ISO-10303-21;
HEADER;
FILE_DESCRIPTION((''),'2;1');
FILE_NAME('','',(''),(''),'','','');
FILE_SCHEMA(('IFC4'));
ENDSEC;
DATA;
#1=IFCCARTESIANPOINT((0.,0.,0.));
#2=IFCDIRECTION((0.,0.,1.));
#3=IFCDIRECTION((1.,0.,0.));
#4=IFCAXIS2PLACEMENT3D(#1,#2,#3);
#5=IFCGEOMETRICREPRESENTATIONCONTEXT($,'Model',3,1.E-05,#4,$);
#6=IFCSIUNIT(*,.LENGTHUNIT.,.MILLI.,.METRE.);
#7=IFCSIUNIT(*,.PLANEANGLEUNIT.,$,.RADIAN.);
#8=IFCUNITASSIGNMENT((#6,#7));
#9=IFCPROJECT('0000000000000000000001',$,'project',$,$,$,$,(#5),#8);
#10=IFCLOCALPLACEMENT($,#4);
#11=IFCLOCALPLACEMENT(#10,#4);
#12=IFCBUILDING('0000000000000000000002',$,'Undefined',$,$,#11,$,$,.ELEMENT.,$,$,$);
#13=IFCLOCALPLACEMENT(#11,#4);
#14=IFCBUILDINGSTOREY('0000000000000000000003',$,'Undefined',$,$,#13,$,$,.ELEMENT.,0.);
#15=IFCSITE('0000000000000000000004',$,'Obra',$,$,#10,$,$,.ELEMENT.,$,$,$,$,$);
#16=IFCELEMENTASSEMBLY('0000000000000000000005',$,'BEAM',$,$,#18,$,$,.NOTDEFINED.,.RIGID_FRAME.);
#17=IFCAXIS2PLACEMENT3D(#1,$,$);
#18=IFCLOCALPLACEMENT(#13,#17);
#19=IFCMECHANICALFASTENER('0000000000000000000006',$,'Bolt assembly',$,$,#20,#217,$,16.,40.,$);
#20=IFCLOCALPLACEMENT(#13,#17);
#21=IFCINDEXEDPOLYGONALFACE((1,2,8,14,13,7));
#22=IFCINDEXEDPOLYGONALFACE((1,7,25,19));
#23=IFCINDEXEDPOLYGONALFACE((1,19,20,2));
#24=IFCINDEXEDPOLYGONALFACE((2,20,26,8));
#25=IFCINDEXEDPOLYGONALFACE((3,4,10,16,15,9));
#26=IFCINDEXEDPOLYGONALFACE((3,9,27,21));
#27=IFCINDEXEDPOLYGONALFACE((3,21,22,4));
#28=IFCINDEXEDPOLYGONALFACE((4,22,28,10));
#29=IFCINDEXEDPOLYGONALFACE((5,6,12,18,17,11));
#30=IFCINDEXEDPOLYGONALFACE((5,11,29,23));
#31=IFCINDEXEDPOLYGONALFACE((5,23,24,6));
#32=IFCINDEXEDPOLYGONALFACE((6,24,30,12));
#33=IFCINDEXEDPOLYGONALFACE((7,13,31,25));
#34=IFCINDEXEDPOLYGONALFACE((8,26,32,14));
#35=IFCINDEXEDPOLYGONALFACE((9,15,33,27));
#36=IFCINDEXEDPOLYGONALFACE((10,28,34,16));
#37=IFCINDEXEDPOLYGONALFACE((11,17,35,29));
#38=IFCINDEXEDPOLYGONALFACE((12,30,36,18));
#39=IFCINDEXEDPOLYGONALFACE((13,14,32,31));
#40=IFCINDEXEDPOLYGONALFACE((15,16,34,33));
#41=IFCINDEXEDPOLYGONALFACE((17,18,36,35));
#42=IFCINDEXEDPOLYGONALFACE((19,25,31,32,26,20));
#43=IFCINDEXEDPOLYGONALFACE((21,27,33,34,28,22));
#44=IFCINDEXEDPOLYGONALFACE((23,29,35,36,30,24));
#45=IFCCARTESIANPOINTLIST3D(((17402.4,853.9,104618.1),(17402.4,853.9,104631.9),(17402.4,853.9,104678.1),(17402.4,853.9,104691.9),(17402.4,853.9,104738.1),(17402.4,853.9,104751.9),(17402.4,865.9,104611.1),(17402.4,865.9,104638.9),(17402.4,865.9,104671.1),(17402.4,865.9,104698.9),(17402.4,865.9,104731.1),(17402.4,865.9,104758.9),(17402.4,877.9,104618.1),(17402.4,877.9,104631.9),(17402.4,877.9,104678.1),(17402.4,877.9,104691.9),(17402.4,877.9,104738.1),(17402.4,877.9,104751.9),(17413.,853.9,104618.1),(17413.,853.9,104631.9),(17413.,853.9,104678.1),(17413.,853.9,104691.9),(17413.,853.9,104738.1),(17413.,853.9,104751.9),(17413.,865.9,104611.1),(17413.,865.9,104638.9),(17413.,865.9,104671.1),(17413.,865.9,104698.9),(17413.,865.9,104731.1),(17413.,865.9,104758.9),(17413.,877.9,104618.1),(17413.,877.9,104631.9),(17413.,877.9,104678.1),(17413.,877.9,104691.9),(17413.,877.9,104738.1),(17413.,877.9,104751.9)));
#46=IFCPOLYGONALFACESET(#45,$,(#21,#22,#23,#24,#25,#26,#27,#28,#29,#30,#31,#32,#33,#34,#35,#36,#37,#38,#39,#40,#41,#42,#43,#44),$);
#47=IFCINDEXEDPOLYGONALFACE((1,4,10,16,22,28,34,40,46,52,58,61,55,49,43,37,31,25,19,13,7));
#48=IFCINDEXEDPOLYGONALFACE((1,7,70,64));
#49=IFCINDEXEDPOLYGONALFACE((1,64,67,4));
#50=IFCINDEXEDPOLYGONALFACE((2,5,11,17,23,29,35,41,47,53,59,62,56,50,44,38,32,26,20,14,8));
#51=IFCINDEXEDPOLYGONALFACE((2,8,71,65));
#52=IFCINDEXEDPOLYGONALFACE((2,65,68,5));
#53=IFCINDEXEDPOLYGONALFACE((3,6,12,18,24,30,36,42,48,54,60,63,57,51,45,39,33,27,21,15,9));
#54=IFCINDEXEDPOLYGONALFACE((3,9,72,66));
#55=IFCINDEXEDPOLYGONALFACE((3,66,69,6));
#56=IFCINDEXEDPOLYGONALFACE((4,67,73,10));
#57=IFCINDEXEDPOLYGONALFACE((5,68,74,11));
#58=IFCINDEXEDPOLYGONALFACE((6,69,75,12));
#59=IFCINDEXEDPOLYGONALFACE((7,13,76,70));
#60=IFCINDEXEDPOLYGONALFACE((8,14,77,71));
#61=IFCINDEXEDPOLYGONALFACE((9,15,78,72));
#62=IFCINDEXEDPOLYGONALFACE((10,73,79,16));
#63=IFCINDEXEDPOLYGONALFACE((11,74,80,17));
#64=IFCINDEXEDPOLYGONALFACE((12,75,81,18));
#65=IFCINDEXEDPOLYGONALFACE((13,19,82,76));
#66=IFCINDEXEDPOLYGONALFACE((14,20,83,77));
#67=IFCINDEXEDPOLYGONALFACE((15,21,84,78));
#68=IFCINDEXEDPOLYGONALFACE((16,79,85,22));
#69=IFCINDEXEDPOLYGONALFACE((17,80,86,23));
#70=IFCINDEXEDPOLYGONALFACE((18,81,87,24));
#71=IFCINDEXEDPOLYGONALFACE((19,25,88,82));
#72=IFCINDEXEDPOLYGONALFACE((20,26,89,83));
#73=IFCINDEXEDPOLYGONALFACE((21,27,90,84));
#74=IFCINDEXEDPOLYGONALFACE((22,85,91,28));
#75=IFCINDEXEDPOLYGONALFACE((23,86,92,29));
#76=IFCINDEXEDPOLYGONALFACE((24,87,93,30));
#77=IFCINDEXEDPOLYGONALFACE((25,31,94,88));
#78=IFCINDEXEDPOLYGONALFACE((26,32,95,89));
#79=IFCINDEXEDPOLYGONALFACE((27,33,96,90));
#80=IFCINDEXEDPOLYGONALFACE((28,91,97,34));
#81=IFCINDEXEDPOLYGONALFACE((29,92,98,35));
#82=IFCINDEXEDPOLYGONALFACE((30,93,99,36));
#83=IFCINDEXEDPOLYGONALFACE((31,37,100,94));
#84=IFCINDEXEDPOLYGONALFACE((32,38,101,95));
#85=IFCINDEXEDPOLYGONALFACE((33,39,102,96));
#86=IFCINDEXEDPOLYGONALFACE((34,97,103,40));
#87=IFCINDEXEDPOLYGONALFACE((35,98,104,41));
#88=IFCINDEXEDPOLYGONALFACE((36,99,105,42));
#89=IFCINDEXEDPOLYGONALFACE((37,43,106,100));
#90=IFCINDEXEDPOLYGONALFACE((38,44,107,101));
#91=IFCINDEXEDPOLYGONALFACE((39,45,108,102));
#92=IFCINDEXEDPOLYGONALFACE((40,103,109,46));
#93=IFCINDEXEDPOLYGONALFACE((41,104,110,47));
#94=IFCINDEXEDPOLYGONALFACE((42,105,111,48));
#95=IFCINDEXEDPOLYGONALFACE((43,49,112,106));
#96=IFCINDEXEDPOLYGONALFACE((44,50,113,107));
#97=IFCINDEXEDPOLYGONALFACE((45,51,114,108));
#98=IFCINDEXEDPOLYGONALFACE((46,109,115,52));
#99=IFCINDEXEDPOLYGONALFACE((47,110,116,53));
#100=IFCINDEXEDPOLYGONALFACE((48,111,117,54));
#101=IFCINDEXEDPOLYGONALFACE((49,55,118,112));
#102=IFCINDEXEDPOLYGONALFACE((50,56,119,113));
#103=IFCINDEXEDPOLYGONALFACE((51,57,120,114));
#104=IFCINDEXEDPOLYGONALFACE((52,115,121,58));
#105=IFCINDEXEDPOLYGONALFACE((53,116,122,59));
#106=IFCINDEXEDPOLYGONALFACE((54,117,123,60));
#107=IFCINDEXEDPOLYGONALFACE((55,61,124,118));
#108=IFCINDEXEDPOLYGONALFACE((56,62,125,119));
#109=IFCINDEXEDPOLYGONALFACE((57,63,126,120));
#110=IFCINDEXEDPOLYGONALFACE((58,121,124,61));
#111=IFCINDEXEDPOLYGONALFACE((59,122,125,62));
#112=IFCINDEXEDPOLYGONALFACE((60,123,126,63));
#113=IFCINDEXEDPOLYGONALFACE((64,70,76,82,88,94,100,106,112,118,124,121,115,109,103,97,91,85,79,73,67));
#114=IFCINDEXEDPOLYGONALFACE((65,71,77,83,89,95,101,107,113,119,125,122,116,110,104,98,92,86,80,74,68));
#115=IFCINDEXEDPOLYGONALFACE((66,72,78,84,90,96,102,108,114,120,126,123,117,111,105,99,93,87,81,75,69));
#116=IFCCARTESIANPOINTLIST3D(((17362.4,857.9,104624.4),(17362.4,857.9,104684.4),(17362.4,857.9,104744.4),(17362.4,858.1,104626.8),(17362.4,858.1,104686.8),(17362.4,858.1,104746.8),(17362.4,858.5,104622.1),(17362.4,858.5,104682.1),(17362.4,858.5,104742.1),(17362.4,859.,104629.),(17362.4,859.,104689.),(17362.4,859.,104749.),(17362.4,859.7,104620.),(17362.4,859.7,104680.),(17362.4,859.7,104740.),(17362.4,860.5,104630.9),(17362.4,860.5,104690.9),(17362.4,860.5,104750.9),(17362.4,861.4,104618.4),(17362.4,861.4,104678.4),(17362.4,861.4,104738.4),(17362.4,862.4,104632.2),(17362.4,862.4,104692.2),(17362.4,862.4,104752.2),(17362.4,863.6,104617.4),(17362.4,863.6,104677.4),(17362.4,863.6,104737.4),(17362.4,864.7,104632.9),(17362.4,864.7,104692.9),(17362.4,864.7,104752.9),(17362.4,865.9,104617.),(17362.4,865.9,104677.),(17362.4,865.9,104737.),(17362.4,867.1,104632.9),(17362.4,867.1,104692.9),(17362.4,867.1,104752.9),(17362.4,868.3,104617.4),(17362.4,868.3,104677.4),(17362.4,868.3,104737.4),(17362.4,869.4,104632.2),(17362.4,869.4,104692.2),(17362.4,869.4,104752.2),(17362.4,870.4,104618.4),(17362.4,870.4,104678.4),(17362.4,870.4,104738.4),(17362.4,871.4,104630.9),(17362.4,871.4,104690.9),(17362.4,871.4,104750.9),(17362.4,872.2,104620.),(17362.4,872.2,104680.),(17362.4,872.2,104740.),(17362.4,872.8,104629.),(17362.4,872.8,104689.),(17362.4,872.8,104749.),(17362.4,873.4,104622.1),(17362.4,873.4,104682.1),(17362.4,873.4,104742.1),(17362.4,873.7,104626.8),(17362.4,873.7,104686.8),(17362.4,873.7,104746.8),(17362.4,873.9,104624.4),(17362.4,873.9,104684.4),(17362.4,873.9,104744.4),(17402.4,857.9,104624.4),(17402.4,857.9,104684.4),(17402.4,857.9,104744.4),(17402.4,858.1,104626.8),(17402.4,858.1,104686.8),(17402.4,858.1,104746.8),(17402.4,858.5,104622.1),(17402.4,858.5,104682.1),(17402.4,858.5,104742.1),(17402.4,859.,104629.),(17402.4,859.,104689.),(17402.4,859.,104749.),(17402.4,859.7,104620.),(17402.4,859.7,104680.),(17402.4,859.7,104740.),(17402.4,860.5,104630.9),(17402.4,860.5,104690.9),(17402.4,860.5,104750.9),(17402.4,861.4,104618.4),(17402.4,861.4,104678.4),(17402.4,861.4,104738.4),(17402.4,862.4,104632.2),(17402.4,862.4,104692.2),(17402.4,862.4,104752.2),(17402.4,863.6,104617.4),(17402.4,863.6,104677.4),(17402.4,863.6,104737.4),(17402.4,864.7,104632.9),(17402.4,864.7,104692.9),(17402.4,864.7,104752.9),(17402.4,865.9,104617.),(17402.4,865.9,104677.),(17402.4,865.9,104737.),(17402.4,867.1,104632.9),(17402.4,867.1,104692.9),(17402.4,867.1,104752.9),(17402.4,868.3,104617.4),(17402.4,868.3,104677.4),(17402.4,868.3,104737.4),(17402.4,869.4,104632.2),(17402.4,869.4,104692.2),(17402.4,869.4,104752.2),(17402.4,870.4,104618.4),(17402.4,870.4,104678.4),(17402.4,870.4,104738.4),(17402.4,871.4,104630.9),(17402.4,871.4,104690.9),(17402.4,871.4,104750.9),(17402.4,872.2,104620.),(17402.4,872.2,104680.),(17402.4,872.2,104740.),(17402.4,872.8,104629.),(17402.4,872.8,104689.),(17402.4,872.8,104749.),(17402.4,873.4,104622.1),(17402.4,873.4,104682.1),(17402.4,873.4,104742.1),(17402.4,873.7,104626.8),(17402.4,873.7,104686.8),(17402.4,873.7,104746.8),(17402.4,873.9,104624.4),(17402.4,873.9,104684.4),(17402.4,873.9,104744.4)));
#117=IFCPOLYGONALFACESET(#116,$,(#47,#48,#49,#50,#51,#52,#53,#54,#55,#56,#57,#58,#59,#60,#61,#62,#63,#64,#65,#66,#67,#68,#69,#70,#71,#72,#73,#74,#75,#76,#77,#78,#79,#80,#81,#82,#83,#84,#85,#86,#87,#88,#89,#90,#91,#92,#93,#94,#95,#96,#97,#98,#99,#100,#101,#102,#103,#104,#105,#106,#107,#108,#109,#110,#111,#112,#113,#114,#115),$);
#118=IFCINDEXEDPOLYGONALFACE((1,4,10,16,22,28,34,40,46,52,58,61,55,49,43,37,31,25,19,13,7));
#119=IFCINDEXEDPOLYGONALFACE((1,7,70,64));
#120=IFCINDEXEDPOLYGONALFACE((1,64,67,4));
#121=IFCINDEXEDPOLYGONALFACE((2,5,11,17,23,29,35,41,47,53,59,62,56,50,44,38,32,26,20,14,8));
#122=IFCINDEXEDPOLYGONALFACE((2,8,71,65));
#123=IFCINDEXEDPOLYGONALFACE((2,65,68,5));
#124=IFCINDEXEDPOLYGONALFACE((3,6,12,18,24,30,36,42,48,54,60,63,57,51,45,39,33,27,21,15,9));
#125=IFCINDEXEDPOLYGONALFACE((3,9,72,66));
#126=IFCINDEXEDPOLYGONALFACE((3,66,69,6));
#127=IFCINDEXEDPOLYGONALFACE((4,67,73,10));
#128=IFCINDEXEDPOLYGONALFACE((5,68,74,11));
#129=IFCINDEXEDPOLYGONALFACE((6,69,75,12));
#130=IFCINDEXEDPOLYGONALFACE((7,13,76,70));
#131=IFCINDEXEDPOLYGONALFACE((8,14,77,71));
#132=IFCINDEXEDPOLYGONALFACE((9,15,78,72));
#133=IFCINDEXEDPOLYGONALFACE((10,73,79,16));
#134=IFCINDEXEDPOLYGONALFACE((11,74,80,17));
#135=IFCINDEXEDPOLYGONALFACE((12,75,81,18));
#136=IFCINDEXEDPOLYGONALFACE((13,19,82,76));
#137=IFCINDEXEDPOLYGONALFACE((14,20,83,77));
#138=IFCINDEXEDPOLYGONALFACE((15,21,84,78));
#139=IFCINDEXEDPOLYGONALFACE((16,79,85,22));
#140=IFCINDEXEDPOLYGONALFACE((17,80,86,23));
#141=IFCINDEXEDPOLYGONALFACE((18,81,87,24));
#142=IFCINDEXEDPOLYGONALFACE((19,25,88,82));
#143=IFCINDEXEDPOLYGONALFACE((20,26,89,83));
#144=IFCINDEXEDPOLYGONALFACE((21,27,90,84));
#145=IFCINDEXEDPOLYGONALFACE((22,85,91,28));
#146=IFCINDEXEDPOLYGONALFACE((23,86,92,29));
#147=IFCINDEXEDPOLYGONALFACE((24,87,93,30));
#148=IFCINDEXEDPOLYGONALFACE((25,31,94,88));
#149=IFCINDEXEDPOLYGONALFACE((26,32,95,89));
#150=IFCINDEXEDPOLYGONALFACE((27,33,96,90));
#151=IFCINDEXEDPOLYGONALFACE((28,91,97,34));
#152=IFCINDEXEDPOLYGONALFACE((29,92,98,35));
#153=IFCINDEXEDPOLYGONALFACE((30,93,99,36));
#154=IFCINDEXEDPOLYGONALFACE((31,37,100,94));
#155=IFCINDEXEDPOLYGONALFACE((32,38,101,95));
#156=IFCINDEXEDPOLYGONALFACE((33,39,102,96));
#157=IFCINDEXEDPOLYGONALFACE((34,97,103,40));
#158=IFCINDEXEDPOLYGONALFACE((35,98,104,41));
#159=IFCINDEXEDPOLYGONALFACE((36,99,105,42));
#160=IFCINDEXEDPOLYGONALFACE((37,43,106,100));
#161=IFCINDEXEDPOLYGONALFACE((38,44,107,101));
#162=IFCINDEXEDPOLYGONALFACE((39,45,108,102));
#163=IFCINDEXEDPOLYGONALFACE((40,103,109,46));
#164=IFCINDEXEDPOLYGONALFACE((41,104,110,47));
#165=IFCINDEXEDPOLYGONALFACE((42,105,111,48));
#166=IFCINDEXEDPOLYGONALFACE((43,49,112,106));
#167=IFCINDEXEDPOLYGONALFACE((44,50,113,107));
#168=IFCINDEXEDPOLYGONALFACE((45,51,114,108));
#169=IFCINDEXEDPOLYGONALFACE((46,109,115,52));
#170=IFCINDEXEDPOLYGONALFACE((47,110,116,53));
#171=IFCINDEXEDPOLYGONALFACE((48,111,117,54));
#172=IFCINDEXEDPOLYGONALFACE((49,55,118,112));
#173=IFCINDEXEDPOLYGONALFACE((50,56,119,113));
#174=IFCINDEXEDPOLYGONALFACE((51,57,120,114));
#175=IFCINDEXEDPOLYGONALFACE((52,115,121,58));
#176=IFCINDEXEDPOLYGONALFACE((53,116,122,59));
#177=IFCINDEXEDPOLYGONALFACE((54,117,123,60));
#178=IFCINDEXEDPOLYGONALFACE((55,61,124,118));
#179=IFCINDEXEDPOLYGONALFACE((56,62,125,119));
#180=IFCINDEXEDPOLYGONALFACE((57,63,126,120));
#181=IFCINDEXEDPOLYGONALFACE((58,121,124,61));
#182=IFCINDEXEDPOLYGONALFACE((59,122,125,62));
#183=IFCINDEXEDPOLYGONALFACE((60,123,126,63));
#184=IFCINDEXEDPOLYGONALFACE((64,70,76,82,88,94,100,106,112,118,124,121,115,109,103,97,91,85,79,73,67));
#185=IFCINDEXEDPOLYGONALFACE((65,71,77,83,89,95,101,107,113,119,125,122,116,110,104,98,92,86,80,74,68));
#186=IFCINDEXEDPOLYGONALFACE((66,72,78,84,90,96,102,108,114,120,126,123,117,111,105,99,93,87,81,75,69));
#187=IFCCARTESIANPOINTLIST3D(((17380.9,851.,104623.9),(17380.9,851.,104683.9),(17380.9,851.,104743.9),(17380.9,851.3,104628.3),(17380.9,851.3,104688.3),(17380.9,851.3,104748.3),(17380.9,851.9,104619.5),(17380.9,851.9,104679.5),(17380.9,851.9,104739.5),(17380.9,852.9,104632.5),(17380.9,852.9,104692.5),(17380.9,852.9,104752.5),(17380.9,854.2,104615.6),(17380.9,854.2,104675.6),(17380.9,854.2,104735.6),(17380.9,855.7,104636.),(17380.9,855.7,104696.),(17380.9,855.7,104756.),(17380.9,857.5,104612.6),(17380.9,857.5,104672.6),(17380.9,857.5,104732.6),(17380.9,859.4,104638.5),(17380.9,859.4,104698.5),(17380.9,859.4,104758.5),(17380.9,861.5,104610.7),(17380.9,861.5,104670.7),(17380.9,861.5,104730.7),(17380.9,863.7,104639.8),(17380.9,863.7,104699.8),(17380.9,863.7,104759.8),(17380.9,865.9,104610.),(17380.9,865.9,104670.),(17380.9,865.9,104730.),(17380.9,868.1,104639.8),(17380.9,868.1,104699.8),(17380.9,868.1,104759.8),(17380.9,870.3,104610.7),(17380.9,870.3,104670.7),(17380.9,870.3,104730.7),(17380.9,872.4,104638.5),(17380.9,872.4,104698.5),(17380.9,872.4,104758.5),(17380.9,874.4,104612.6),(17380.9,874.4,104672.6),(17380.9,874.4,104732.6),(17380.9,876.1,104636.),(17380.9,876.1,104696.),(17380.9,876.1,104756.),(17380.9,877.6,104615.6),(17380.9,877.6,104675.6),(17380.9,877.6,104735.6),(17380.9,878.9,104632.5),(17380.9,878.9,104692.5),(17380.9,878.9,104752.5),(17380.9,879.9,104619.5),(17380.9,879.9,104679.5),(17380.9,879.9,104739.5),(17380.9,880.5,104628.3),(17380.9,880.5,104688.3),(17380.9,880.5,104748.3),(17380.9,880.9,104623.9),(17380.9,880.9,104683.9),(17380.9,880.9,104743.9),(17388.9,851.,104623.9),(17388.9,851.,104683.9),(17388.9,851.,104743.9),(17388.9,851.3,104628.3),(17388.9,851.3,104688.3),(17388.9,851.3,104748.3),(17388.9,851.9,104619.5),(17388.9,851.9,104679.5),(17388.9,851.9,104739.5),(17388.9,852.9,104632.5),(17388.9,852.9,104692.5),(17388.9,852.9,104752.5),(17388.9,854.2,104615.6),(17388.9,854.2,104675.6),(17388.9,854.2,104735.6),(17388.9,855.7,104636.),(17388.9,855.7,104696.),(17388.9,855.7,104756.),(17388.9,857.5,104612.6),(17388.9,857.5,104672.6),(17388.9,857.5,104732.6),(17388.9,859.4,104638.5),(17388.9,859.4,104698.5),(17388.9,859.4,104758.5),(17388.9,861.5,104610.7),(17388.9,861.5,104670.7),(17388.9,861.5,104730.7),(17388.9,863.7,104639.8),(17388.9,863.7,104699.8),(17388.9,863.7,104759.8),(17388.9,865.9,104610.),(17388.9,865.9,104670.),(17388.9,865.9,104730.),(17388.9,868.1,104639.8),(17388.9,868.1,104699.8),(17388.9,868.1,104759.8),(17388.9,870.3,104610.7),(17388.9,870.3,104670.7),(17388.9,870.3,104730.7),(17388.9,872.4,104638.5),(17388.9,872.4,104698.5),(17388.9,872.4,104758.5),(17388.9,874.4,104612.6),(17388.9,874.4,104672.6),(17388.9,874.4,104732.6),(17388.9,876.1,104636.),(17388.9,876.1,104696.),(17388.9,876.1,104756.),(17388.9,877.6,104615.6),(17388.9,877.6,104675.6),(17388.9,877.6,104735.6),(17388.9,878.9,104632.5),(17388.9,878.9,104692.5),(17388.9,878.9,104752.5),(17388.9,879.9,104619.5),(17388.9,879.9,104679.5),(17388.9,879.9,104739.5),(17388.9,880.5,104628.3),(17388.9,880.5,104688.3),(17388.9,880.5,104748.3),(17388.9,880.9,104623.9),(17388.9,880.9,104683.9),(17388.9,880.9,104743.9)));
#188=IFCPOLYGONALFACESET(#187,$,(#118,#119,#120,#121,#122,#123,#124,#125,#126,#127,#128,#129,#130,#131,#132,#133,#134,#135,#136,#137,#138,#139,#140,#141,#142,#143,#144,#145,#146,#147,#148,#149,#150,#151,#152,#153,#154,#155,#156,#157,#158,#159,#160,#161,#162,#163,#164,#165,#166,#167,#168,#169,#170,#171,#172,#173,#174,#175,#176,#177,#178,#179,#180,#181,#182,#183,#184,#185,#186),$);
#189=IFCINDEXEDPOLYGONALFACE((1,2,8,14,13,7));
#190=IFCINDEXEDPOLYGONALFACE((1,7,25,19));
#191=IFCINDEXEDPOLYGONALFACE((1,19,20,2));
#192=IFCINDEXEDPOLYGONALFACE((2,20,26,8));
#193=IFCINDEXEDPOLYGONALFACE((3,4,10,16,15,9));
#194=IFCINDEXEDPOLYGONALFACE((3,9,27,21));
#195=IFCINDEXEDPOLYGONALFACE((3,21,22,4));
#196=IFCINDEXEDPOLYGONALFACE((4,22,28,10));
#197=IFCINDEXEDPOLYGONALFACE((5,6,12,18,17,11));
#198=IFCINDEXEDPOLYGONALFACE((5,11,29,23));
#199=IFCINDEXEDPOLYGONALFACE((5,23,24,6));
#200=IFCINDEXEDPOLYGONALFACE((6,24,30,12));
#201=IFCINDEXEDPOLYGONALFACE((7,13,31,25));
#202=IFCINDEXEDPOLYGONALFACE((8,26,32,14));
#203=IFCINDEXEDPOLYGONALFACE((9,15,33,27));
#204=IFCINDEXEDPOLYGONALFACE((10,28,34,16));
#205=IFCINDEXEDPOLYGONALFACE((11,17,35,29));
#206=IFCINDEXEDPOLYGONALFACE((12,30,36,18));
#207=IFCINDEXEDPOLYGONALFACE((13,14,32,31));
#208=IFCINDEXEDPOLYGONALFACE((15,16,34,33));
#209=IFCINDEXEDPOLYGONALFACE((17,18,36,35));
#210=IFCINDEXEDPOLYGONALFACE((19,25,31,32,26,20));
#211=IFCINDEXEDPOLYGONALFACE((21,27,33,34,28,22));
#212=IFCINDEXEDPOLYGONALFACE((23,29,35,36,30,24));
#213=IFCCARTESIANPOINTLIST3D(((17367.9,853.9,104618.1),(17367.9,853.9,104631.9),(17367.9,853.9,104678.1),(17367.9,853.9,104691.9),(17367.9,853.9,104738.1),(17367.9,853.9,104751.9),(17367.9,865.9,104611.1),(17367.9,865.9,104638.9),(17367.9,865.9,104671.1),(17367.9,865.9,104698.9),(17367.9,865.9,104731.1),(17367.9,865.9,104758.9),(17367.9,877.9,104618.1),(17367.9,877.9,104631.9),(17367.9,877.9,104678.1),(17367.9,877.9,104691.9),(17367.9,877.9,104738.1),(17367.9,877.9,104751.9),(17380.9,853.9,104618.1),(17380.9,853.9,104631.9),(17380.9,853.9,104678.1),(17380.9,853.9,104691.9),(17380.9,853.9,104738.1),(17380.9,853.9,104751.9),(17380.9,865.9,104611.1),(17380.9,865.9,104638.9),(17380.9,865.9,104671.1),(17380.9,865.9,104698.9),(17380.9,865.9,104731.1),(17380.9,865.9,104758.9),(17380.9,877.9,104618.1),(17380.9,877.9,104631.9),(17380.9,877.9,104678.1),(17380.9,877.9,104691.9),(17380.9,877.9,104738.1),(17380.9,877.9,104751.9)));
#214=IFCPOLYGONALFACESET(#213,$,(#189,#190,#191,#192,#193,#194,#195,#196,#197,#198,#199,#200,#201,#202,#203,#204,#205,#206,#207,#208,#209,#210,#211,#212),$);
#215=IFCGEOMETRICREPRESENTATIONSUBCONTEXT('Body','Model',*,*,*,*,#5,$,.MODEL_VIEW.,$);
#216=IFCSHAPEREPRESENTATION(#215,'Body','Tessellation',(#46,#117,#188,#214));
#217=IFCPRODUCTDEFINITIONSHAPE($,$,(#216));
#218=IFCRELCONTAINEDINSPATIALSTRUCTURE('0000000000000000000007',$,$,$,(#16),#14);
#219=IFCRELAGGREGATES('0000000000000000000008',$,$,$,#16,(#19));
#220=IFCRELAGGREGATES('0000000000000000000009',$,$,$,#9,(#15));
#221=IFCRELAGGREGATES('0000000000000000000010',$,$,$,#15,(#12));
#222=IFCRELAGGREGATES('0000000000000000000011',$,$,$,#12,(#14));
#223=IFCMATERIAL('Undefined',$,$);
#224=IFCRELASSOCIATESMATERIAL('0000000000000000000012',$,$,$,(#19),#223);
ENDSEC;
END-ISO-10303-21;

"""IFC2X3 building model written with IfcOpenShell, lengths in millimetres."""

from ifc_helpers import new_model, si_unit, frame, origin_with_axes, origin_2d_with_axis, place, context, subcontext, project, spatial, polyline, circle, outline, extrude, source, transform, mapped, material, element, aggregate, save


model = new_model("IFC2X3")

# Units and contexts
model_context = context("Model", 3, precision=1e-05, world=origin_with_axes())
body_context = subcontext(model_context, "Body", "Model", "MODEL_VIEW")
ifc_project = project(units=[si_unit("LENGTHUNIT", "METRE", prefix="MILLI"), si_unit("PLANEANGLEUNIT", "RADIAN")], contexts=[model_context])

# Site, building, storey
site_placement = place(None, origin_with_axes())
site = spatial("IfcSite", under=ifc_project, at=site_placement, Name="Obra", CompositionType="ELEMENT")
building_placement = place(site_placement, origin_with_axes())
building = spatial("IfcBuilding", under=site, at=building_placement, Name="Undefined", CompositionType="ELEMENT")
storey_placement = place(building_placement, origin_with_axes())
storey = spatial("IfcBuildingStorey", under=building, at=storey_placement, Name="Undefined", CompositionType="ELEMENT", Elevation=0.0)

# Shared definitions
ifc_material_1 = material(Name="Undefined")
shared_shape_1 = source(origin_with_axes(), body_context, "Body", "SweptSolid", [
    extrude(outline(polyline([(13.9, 0.0), (6.9, 12.0), (-6.9, 12.0), (-13.9, 0.0), (-6.9, -12.0), (6.9, -12.0), (13.9, 0.0)])), frame((0.0, -20.3, 0.0), z_axis=(0.0, 1.0, 0.0), x_axis=(1.0, 0.0, 0.0)), (0.0, 0.0, 1.0), 10.6),
    extrude(circle(Radius=8.0, at=origin_2d_with_axis()), frame((0.0, -9.8, 0.0), z_axis=(0.0, 1.0, 0.0), x_axis=(1.0, 0.0, 0.0)), (0.0, 0.0, 1.0), 40.0),
    extrude(circle(Radius=15.0, at=origin_2d_with_axis()), frame((0.0, 3.7, 0.0), z_axis=(0.0, 1.0, 0.0), x_axis=(1.0, 0.0, 0.0)), (0.0, 0.0, 1.0), 8.0),
    extrude(outline(polyline([(13.9, 0.0), (6.9, 12.0), (-6.9, 12.0), (-13.9, 0.0), (-6.9, -12.0), (6.9, -12.0), (13.9, 0.0)])), frame((0.0, 11.7, 0.0), z_axis=(0.0, 1.0, 0.0), x_axis=(1.0, 0.0, 0.0)), (0.0, 0.0, 1.0), 13.0),
])

# Element assembly, mechanical fastener
assembly_1_placement = place(storey_placement, origin_with_axes())
assembly_1 = element("IfcElementAssembly", 1, at=assembly_1_placement, inside=storey, Name="BEAM", AssemblyPlace="NOTDEFINED", PredefinedType="RIGID_FRAME")
mechanical_fastener_1_placement = place(assembly_1_placement, frame((17392.7, 830.9, 104850.0), z_axis=(0.0, 1.0, 0.0), x_axis=(0.0, 0.0, -1.0)))
mechanical_fastener_1 = element("IfcMechanicalFastener", 2, at=mechanical_fastener_1_placement, material=ifc_material_1, Name="Bolt assembly", NominalDiameter=16.0, NominalLength=40.0, context=body_context, shape_type="MappedRepresentation", body=[
    mapped(shared_shape_1, transform((105.0, 0.0, 35.0))),
    mapped(shared_shape_1, transform((165.0, 0.0, 35.0))),
    mapped(shared_shape_1, transform((225.0, 0.0, 35.0))),
])
aggregate(assembly_1, [mechanical_fastener_1])

save(model, "model.ifc")
